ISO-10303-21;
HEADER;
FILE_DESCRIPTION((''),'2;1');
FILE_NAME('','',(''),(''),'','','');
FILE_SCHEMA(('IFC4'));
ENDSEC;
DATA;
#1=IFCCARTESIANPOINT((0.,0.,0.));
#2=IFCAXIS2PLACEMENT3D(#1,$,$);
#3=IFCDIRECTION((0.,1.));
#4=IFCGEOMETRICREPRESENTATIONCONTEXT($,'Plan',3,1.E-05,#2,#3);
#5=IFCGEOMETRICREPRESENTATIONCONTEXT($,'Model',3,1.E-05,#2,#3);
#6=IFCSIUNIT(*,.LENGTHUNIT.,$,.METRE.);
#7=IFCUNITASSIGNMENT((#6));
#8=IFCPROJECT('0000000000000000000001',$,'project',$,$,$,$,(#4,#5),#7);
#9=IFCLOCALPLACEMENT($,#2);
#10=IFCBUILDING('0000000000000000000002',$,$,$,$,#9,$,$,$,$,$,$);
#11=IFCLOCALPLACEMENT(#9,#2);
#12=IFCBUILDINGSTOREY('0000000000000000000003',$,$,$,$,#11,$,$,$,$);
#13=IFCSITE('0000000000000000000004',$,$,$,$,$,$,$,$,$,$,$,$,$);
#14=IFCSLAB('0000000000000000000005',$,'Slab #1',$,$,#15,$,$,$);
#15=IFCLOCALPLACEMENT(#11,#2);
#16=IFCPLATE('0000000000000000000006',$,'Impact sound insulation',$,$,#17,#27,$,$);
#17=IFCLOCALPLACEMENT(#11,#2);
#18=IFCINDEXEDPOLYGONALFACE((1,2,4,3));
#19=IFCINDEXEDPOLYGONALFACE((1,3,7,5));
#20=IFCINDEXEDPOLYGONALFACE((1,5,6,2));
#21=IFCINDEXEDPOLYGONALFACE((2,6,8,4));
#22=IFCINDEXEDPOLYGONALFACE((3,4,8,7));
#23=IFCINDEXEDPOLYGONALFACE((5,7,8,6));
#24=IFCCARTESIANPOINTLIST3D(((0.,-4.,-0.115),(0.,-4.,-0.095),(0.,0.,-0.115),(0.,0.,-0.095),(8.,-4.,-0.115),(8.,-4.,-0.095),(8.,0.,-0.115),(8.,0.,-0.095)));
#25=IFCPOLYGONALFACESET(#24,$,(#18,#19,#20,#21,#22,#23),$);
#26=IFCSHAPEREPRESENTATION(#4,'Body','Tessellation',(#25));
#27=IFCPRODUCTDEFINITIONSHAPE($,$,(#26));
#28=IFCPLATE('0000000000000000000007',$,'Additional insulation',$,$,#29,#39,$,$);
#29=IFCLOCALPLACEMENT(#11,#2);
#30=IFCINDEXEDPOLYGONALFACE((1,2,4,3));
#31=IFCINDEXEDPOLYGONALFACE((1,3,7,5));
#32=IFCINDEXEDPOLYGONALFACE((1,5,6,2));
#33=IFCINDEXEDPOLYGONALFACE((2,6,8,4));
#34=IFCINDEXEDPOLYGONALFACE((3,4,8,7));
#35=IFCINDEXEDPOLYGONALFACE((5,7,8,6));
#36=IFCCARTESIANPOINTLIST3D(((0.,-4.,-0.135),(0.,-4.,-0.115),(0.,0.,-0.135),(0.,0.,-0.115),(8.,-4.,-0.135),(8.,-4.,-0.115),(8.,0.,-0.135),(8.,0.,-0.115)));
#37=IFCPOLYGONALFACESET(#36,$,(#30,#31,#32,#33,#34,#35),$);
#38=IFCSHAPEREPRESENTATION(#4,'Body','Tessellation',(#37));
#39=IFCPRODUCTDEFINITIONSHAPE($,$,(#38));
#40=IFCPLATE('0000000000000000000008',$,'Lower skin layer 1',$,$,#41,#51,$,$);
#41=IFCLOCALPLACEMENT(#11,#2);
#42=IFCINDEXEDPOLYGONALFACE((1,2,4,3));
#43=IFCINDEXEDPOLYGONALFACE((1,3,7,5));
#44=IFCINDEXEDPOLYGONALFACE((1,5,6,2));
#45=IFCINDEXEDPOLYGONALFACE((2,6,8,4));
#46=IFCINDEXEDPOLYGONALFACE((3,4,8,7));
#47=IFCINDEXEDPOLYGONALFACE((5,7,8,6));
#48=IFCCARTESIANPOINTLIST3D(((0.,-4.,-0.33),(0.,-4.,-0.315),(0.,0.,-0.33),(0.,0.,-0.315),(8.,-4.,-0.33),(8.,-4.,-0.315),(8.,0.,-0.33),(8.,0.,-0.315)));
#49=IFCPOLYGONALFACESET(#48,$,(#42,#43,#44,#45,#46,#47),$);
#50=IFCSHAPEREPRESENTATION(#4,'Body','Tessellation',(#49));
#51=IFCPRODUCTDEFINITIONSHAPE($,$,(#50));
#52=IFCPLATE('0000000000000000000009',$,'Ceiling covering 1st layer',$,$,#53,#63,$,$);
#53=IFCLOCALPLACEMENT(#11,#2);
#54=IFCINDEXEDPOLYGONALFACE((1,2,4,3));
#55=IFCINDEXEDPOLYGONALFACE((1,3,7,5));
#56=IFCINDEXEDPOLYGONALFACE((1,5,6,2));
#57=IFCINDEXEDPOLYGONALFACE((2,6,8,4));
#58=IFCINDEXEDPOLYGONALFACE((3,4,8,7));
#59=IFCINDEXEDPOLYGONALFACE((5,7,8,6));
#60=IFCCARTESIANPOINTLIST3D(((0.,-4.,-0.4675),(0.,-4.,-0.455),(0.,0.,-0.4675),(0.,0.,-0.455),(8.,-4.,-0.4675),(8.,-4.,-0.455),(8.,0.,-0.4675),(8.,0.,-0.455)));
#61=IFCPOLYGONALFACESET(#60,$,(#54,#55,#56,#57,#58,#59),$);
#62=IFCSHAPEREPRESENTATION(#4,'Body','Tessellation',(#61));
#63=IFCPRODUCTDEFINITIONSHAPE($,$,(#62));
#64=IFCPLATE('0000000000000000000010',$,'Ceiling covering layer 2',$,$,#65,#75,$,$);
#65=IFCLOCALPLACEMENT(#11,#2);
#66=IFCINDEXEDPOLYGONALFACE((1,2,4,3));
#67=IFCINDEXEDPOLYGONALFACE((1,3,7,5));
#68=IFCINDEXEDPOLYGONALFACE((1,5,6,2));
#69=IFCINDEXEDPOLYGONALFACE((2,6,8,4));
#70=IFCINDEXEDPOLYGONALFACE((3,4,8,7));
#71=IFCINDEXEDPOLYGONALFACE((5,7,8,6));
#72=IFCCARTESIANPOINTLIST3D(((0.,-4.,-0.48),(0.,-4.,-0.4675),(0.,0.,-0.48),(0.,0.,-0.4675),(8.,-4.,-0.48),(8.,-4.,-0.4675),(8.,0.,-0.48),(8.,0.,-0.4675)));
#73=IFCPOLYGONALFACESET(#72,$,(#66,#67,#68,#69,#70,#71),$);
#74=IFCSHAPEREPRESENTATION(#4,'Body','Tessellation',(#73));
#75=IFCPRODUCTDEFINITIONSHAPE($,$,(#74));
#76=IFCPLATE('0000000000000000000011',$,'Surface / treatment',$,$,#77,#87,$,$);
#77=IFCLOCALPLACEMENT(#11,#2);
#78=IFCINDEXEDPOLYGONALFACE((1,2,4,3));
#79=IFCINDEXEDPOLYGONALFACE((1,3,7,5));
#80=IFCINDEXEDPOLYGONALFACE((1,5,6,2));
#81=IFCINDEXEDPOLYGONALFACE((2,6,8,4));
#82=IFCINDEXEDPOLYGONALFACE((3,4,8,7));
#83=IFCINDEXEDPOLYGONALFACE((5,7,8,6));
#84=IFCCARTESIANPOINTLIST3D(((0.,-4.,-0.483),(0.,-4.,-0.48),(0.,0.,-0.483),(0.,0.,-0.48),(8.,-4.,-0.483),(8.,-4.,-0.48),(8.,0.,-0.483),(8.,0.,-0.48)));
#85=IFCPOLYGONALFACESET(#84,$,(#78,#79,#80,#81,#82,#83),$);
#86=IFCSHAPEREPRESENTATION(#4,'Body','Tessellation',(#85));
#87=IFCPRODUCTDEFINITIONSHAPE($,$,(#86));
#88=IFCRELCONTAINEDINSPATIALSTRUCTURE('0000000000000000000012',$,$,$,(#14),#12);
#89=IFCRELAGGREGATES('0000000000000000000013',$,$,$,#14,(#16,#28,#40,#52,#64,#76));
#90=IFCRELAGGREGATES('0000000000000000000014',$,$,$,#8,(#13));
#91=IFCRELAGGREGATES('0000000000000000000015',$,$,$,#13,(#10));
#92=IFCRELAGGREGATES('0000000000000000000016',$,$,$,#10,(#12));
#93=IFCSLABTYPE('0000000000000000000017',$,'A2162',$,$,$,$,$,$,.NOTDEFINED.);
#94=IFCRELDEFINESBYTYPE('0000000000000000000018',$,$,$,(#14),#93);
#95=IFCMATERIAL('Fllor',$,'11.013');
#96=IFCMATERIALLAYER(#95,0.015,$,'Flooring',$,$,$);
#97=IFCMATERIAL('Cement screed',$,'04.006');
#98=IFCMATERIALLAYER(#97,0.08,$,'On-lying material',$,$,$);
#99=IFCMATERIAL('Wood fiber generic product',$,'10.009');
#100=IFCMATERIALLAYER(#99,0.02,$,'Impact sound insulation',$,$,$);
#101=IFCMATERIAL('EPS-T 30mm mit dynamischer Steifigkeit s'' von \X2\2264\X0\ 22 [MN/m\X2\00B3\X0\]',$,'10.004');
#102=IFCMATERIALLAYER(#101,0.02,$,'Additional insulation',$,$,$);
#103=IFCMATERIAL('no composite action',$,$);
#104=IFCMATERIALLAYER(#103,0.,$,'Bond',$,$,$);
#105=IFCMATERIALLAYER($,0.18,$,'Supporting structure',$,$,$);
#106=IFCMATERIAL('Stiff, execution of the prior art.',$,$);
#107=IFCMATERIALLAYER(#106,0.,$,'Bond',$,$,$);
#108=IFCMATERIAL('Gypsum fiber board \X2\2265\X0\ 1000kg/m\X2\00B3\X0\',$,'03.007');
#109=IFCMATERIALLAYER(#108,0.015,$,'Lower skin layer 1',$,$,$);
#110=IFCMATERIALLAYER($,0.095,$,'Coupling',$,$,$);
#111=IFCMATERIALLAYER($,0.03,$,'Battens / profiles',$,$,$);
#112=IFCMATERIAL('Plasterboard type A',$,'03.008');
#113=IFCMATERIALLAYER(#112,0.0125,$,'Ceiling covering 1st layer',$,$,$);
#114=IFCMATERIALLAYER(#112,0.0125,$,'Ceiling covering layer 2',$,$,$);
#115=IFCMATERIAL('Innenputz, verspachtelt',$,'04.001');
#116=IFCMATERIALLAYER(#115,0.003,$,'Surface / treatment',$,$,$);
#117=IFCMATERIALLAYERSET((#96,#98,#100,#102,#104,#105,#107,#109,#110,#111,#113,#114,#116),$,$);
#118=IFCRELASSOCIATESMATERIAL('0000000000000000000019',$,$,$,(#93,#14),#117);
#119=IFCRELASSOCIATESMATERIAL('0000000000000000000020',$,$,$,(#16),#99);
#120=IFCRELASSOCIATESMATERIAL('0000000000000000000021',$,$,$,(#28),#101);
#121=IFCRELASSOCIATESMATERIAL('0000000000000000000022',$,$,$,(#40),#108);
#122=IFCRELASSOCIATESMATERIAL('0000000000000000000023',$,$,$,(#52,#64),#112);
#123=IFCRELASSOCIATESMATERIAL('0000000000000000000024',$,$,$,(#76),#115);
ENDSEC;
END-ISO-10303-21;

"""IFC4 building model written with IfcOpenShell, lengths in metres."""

from ifc_helpers import new_model, si_unit, direction, frame, frame_2d, origin, place, context, project, spatial, rectangle, extrude, material, layer, layer_set, type_object, element, aggregate, save


model = new_model("IFC4")

# Units and contexts
plan_context = context("Plan", 3, precision=1e-05, world=origin(), true_north=direction((0.0, 1.0)))
model_context = context("Model", 3, precision=1e-05, world=origin(), true_north=direction((0.0, 1.0)))
ifc_project = project(units=[si_unit("LENGTHUNIT", "METRE")], contexts=[plan_context, model_context])

# Site, building, storey
site = spatial("IfcSite", under=ifc_project)
building_placement = place(None, origin())
building = spatial("IfcBuilding", under=site, at=building_placement)
storey_placement = place(building_placement, origin())
storey = spatial("IfcBuildingStorey", under=building, at=storey_placement)

# Slab, plates
ifc_material_1 = material(Name="Fllor", Category="11.013")
ifc_layer_1 = layer(ifc_material_1, 0.015, Name="Flooring")
ifc_material_2 = material(Name="Cement screed", Category="04.006")
ifc_layer_2 = layer(ifc_material_2, 0.08, Name="On-lying material")
ifc_material_3 = material(Name="Wood fiber generic product", Category="10.009")
ifc_layer_3 = layer(ifc_material_3, 0.02, Name="Impact sound insulation")
ifc_material_4 = material(Name="EPS-T 30mm mit dynamischer Steifigkeit s' von ≤ 22 [MN/m³]", Category="10.004")
ifc_layer_4 = layer(ifc_material_4, 0.02, Name="Additional insulation")
ifc_material_5 = material(Name="no composite action")
ifc_layer_5 = layer(ifc_material_5, 0.0, Name="Bond")
ifc_layer_6 = layer(None, 0.18, Name="Supporting structure")
ifc_material_6 = material(Name="Stiff, execution of the prior art.")
ifc_layer_7 = layer(ifc_material_6, 0.0, Name="Bond")
ifc_material_7 = material(Name="Gypsum fiber board ≥ 1000kg/m³", Category="03.007")
ifc_layer_8 = layer(ifc_material_7, 0.015, Name="Lower skin layer 1")
ifc_layer_9 = layer(None, 0.095, Name="Coupling")
ifc_layer_10 = layer(None, 0.03, Name="Battens / profiles")
ifc_material_8 = material(Name="Plasterboard type A", Category="03.008")
ifc_layer_11 = layer(ifc_material_8, 0.0125, Name="Ceiling covering 1st layer")
ifc_layer_12 = layer(ifc_material_8, 0.0125, Name="Ceiling covering layer 2")
ifc_material_9 = material(Name="Innenputz, verspachtelt", Category="04.001")
ifc_layer_13 = layer(ifc_material_9, 0.003, Name="Surface / treatment")
ifc_layer_set = layer_set([ifc_layer_1, ifc_layer_2, ifc_layer_3, ifc_layer_4, ifc_layer_5, ifc_layer_6, ifc_layer_7, ifc_layer_8, ifc_layer_9, ifc_layer_10, ifc_layer_11, ifc_layer_12, ifc_layer_13])
slab_type = type_object("IfcSlabType", Name="A2162", PredefinedType="NOTDEFINED", material=ifc_layer_set)
slab_placement = place(None, frame((0.0, 0.0, 0.0), z_axis=(0.0, 0.0, -1.0), x_axis=(1.0, 0.0, 0.0)))
slab = element("IfcSlab", 1, at=slab_placement, inside=storey, type_object=slab_type, material=ifc_layer_set, Name="Slab #1")
plate_1_placement = place(slab_placement, origin())
plate_1 = element("IfcPlate", 2, at=plate_1_placement, material=ifc_material_3, Name="Impact sound insulation", context=plan_context, shape_type="SweptSolid", body=[
    extrude(rectangle(XDim=8.0, YDim=4.0, at=frame_2d((4.0, 2.0), x_axis=(1.0, 0.0))), frame((0.0, 0.0, 0.095), z_axis=(0.0, 0.0, 1.0), x_axis=(1.0, 0.0, 0.0)), (0.0, 0.0, 1.0), 0.02),
])
plate_2_placement = place(slab_placement, origin())
plate_2 = element("IfcPlate", 3, at=plate_2_placement, material=ifc_material_4, Name="Additional insulation", context=plan_context, shape_type="SweptSolid", body=[
    extrude(rectangle(XDim=8.0, YDim=4.0, at=frame_2d((4.0, 2.0), x_axis=(1.0, 0.0))), frame((0.0, 0.0, 0.115), z_axis=(0.0, 0.0, 1.0), x_axis=(1.0, 0.0, 0.0)), (0.0, 0.0, 1.0), 0.02),
])
plate_3_placement = place(slab_placement, origin())
plate_3 = element("IfcPlate", 4, at=plate_3_placement, material=ifc_material_7, Name="Lower skin layer 1", context=plan_context, shape_type="SweptSolid", body=[
    extrude(rectangle(XDim=8.0, YDim=4.0, at=frame_2d((4.0, 2.0), x_axis=(1.0, 0.0))), frame((0.0, 0.0, 0.315), z_axis=(0.0, 0.0, 1.0), x_axis=(1.0, 0.0, 0.0)), (0.0, 0.0, 1.0), 0.015),
])
plate_4_placement = place(slab_placement, origin())
plate_4 = element("IfcPlate", 5, at=plate_4_placement, material=ifc_material_8, Name="Ceiling covering 1st layer", context=plan_context, shape_type="SweptSolid", body=[
    extrude(rectangle(XDim=8.0, YDim=4.0, at=frame_2d((4.0, 2.0), x_axis=(1.0, 0.0))), frame((0.0, 0.0, 0.455), z_axis=(0.0, 0.0, 1.0), x_axis=(1.0, 0.0, 0.0)), (0.0, 0.0, 1.0), 0.0125),
])
plate_5_placement = place(slab_placement, origin())
plate_5 = element("IfcPlate", 6, at=plate_5_placement, material=ifc_material_8, Name="Ceiling covering layer 2", context=plan_context, shape_type="SweptSolid", body=[
    extrude(rectangle(XDim=8.0, YDim=4.0, at=frame_2d((4.0, 2.0), x_axis=(1.0, 0.0))), frame((0.0, 0.0, 0.4675), z_axis=(0.0, 0.0, 1.0), x_axis=(1.0, 0.0, 0.0)), (0.0, 0.0, 1.0), 0.0125),
])
plate_6_placement = place(slab_placement, origin())
plate_6 = element("IfcPlate", 7, at=plate_6_placement, material=ifc_material_9, Name="Surface / treatment", context=plan_context, shape_type="SweptSolid", body=[
    extrude(rectangle(XDim=8.0, YDim=4.0, at=frame_2d((4.0, 2.0), x_axis=(1.0, 0.0))), frame((0.0, 0.0, 0.48), z_axis=(0.0, 0.0, 1.0), x_axis=(1.0, 0.0, 0.0)), (0.0, 0.0, 1.0), 0.003),
])
aggregate(slab, [plate_1, plate_2, plate_3, plate_4, plate_5, plate_6])

save(model, "model.ifc")
